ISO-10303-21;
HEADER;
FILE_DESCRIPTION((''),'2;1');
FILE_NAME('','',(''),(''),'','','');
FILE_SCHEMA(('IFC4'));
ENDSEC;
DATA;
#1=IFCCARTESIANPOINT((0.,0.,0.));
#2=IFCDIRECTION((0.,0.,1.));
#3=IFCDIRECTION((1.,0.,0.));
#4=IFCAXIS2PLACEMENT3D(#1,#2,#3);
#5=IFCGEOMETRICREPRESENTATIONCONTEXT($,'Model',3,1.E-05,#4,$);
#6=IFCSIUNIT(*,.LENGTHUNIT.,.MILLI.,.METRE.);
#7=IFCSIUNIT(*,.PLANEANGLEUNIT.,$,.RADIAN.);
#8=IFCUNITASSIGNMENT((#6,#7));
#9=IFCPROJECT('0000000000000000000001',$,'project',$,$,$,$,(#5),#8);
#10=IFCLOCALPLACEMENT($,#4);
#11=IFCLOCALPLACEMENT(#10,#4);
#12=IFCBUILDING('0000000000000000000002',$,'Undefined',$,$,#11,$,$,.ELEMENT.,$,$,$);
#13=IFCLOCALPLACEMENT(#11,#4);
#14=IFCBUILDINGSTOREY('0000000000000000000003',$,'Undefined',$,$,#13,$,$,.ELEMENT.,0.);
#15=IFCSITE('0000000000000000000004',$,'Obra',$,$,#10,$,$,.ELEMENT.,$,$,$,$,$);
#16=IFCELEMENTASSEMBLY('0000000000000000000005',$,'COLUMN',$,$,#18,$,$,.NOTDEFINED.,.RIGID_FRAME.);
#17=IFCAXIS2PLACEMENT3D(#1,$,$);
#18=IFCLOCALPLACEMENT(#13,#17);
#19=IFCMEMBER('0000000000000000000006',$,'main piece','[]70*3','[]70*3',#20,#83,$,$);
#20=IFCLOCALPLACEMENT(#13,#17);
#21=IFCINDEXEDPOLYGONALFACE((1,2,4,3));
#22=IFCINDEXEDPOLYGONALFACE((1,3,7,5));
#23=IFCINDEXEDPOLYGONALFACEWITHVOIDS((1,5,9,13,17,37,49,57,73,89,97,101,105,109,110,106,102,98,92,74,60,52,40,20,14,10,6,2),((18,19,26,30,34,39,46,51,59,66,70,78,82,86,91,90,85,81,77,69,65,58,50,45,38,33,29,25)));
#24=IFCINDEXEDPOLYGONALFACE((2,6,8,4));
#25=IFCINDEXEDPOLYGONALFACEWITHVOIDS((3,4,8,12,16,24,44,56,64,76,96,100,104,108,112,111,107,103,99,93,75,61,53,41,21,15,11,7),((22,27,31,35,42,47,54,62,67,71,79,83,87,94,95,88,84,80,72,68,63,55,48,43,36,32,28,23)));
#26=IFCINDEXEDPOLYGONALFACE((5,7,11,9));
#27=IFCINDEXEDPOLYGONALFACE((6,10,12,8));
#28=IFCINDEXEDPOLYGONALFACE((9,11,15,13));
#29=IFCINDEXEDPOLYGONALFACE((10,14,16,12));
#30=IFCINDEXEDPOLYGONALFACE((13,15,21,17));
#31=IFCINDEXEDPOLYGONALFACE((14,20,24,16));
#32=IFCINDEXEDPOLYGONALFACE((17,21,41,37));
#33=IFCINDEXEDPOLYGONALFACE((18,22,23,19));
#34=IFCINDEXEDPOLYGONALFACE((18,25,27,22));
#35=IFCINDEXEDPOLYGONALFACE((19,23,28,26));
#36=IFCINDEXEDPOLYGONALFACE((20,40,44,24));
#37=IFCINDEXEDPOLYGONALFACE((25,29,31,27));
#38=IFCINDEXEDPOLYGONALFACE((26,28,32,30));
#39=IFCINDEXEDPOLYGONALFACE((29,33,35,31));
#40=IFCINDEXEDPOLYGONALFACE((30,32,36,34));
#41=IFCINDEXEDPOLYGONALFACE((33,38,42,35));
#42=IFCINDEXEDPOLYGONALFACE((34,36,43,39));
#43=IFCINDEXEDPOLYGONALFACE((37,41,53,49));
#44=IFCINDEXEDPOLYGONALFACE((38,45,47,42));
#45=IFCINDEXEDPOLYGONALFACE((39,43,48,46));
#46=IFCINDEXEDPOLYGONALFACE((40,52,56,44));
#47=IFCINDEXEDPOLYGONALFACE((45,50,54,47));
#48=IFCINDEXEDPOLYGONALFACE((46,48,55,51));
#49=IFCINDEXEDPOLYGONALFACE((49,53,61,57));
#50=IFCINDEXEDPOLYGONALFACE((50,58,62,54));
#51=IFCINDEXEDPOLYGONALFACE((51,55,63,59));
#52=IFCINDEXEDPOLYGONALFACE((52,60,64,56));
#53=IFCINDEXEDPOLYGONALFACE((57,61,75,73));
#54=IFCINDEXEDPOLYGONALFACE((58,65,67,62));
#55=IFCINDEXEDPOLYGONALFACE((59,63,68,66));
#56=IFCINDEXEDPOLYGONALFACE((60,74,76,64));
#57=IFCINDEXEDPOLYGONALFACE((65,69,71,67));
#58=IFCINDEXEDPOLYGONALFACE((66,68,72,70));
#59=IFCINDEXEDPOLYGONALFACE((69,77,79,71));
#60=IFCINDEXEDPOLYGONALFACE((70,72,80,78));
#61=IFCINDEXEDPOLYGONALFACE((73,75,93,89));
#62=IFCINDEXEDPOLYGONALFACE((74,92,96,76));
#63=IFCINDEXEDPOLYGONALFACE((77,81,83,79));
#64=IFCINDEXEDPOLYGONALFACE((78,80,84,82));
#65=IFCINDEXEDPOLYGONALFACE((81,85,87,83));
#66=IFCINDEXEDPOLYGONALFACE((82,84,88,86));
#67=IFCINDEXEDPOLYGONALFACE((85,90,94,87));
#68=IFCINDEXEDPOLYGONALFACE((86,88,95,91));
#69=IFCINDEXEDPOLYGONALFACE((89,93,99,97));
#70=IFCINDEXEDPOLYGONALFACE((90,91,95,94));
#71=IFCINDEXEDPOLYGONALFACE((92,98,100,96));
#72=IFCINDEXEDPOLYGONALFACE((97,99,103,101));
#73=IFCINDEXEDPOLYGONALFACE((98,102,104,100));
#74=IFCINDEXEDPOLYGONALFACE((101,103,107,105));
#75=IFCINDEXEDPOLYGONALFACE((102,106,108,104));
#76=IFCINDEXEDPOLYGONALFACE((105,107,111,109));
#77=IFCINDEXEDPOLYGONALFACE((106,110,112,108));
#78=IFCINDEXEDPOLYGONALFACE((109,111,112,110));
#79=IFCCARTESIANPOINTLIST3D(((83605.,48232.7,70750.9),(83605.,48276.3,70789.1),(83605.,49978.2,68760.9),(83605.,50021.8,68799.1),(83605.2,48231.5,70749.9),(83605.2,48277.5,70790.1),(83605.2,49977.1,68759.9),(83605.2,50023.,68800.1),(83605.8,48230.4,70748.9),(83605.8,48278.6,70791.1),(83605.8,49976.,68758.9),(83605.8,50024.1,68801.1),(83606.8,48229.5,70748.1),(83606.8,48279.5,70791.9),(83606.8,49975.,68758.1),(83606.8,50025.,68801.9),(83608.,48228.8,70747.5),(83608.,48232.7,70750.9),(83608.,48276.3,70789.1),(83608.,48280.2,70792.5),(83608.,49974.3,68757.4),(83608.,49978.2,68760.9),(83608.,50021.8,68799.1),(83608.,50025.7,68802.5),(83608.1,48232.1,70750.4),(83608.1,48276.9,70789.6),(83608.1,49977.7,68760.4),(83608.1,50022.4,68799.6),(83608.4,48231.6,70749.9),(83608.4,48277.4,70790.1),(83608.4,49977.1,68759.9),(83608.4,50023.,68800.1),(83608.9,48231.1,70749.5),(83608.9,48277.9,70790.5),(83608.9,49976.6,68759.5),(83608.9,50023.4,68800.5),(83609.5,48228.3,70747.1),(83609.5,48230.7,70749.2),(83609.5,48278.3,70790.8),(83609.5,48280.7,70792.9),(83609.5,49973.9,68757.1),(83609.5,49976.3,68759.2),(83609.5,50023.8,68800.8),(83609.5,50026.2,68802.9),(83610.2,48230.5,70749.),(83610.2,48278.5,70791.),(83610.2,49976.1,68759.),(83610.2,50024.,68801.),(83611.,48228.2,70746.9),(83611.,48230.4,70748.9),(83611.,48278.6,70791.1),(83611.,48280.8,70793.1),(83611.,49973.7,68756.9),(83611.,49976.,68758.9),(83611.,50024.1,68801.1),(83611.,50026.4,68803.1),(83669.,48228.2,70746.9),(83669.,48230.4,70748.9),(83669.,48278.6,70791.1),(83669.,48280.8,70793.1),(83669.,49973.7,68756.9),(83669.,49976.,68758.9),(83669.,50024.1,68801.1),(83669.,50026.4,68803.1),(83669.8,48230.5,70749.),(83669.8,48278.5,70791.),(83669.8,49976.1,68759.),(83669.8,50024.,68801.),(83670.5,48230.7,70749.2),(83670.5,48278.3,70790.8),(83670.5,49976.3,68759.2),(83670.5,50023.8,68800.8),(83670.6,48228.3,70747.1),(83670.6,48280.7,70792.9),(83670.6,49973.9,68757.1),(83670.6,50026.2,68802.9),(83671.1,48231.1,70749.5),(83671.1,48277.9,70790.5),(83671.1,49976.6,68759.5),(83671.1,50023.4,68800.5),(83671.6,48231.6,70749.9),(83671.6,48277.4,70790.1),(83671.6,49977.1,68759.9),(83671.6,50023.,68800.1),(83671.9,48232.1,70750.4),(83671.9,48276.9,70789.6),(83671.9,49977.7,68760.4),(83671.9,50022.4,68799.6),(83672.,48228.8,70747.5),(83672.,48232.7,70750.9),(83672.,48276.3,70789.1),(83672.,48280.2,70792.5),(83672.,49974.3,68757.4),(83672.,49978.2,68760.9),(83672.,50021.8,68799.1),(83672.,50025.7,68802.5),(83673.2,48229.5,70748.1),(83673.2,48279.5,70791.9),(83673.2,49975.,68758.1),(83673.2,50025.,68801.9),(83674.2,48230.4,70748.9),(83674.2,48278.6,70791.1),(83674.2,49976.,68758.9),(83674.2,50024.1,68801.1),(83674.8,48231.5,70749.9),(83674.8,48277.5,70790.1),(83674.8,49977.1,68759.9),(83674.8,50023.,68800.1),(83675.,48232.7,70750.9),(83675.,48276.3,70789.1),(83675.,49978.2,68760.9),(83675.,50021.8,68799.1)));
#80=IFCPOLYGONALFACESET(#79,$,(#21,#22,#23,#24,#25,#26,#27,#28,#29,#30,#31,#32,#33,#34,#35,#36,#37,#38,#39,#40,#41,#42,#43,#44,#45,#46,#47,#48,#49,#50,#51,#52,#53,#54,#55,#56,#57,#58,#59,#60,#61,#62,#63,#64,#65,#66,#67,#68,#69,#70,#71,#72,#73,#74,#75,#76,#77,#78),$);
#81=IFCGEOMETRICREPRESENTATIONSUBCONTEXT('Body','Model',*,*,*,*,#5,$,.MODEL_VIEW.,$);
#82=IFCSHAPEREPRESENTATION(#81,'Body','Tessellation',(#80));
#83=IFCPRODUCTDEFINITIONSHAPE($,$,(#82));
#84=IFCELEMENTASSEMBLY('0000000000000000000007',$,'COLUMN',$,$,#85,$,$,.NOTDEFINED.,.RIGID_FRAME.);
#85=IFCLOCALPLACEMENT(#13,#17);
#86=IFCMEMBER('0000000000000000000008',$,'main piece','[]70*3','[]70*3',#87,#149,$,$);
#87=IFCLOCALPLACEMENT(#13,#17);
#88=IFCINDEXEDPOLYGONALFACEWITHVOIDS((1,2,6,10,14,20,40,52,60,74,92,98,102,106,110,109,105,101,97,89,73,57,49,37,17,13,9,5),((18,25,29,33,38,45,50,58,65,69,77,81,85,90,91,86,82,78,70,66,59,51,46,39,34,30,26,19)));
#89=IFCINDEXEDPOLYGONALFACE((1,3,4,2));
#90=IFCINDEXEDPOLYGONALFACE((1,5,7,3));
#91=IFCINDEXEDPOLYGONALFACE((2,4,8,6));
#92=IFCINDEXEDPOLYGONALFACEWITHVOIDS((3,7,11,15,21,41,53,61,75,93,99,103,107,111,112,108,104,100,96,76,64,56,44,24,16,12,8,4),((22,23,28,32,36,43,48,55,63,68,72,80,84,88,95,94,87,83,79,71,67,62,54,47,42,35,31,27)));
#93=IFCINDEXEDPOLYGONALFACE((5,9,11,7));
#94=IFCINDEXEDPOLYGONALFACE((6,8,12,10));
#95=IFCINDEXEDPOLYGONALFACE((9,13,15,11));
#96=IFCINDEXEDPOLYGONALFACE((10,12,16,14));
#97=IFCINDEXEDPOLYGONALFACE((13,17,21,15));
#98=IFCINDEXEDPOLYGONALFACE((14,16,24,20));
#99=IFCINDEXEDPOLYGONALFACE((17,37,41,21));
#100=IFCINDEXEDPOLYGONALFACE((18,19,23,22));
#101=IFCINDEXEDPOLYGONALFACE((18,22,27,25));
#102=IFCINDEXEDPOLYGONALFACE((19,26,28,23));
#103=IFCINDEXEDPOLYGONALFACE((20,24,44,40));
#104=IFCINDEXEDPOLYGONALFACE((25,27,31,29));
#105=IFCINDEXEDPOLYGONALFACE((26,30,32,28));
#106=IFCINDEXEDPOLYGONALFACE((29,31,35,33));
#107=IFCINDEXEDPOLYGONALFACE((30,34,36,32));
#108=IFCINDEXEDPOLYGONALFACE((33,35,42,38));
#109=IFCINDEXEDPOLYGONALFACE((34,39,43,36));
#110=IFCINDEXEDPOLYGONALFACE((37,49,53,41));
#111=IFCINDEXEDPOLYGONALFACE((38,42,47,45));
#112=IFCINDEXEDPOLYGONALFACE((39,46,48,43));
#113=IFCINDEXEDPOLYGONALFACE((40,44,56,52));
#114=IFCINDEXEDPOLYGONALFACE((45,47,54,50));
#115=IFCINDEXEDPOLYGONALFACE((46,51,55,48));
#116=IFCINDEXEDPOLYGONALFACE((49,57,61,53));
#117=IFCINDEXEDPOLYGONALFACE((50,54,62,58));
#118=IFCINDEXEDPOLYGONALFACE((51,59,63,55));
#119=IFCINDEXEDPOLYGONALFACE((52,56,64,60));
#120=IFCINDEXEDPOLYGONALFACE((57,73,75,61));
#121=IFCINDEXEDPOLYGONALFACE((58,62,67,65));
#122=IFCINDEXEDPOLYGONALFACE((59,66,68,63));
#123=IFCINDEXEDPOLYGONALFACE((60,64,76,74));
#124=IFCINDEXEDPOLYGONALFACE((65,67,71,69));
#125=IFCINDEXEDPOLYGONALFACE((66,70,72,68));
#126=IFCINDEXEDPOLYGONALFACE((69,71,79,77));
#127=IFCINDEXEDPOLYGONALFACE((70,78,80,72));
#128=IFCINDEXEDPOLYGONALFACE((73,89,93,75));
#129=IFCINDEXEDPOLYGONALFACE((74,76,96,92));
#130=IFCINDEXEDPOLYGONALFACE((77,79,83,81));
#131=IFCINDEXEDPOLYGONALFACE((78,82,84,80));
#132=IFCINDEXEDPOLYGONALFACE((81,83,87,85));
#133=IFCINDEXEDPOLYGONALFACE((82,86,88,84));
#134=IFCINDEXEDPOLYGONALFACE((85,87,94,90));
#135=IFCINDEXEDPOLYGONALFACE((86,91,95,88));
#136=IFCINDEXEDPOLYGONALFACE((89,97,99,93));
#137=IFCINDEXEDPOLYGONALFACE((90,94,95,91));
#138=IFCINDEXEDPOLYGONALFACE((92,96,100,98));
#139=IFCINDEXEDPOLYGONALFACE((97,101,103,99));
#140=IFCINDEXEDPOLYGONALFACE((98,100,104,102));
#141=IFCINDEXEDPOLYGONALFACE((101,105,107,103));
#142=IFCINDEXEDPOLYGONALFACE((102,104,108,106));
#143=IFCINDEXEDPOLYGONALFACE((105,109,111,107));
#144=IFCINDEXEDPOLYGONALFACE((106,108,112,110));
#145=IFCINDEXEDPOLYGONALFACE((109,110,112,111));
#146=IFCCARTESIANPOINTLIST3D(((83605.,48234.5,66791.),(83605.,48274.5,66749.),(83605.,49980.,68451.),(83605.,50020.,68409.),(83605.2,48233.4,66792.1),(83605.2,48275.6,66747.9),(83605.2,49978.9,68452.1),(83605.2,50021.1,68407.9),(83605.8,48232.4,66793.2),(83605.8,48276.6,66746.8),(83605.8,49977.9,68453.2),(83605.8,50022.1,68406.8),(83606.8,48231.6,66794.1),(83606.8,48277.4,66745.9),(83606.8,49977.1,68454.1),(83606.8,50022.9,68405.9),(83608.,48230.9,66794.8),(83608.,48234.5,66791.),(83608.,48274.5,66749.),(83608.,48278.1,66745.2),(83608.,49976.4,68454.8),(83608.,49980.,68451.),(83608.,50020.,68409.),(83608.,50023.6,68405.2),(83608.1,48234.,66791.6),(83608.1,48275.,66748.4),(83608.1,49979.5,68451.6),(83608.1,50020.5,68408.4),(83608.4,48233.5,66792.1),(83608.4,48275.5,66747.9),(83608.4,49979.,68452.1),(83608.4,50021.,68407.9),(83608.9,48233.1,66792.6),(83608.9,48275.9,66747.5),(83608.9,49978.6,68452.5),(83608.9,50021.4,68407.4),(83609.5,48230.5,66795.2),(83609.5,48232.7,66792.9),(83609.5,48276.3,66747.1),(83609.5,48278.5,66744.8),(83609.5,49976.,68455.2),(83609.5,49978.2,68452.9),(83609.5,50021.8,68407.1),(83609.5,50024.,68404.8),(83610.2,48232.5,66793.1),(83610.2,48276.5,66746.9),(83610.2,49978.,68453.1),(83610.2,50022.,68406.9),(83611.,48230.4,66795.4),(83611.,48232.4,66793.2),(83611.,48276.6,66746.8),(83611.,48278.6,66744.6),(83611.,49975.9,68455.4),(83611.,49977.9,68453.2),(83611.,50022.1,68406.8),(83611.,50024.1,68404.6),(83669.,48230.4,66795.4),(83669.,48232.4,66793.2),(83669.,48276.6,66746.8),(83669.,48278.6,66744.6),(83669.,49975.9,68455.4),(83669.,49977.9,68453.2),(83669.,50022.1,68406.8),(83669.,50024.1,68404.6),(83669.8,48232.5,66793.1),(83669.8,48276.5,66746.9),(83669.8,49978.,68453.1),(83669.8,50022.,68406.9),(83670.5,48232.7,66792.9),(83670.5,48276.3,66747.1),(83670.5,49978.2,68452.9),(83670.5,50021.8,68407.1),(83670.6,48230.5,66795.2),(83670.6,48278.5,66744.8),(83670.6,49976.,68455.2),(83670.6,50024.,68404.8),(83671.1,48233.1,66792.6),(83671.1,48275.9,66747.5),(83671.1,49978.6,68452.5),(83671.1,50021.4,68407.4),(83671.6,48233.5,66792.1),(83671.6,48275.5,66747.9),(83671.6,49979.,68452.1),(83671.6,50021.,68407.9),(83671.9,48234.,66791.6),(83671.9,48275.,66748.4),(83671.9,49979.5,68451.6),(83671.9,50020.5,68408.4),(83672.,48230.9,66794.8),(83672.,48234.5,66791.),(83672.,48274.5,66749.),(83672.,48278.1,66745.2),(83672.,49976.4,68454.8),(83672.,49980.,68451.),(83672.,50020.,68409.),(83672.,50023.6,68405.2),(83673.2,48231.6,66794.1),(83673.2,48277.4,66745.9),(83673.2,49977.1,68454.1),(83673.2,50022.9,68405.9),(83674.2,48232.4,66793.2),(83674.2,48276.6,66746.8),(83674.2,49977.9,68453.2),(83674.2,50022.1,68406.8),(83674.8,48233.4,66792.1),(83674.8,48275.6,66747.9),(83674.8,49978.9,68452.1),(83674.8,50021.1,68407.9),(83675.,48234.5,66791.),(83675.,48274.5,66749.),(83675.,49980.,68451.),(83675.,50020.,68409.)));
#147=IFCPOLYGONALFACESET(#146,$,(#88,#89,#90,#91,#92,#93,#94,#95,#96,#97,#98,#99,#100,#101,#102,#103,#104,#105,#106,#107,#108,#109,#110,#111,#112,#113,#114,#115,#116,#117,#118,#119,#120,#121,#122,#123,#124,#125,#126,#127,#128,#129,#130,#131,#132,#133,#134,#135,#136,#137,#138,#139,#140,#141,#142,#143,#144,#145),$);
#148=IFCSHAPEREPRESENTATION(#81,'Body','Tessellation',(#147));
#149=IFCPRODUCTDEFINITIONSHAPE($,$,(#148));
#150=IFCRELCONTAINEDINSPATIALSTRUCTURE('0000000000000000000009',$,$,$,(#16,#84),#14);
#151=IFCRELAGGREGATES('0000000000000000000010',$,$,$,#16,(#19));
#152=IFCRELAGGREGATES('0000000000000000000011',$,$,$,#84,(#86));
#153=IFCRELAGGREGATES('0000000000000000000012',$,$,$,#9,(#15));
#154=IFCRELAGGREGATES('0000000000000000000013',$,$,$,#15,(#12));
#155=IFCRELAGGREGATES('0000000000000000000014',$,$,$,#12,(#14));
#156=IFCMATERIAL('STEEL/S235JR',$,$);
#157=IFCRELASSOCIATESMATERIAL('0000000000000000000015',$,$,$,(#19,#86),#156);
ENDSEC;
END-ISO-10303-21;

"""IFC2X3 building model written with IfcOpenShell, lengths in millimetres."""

from ifc_helpers import new_model, si_unit, frame, origin_with_axes, origin_2d_with_axis, place, context, subcontext, project, spatial, hollow_rectangle, extrude, material, element, aggregate, save


model = new_model("IFC2X3")

# Units and contexts
model_context = context("Model", 3, precision=1e-05, world=origin_with_axes())
body_context = subcontext(model_context, "Body", "Model", "MODEL_VIEW")
ifc_project = project(units=[si_unit("LENGTHUNIT", "METRE", prefix="MILLI"), si_unit("PLANEANGLEUNIT", "RADIAN")], contexts=[model_context])

# Site, building, storey
site_placement = place(None, origin_with_axes())
site = spatial("IfcSite", under=ifc_project, at=site_placement, Name="Obra", CompositionType="ELEMENT")
building_placement = place(site_placement, origin_with_axes())
building = spatial("IfcBuilding", under=site, at=building_placement, Name="Undefined", CompositionType="ELEMENT")
storey_placement = place(building_placement, origin_with_axes())
storey = spatial("IfcBuildingStorey", under=building, at=storey_placement, Name="Undefined", CompositionType="ELEMENT", Elevation=0.0)

# Shared definitions
ifc_material = material(Name="STEEL/S235JR")

# Element assemblies, members
assembly_1_placement = place(storey_placement, origin_with_axes())
assembly_1 = element("IfcElementAssembly", 1, at=assembly_1_placement, inside=storey, Name="COLUMN", AssemblyPlace="NOTDEFINED", PredefinedType="RIGID_FRAME")
member_1_placement = place(assembly_1_placement, frame((83640.0, 50000.0, 68780.0), z_axis=(1.0, 0.0, 0.0), x_axis=(0.0, -0.659423, 0.751772)))
member_1 = element("IfcMember", 2, at=member_1_placement, material=ifc_material, Name="main piece", Description="[]70*3", ObjectType="[]70*3", context=body_context, shape_type="SweptSolid", body=[
    extrude(hollow_rectangle(XDim=70.0, YDim=70.0, WallThickness=3.0, InnerFilletRadius=3.0, OuterFilletRadius=6.0, at=origin_2d_with_axis()), frame((2647.1, 0.0, 0.0), z_axis=(-1.0, 0.0, 0.0), x_axis=(0.0, -1.0, 0.0)), (0.0, 0.0, 1.0), 2647.1),
])
aggregate(assembly_1, [member_1])
assembly_2_placement = place(storey_placement, origin_with_axes())
assembly_2 = element("IfcElementAssembly", 3, at=assembly_2_placement, inside=storey, Name="COLUMN", AssemblyPlace="NOTDEFINED", PredefinedType="RIGID_FRAME")
member_2_placement = place(assembly_2_placement, frame((83640.0, 48254.5, 66770.0), z_axis=(-1.0, 0.0, 0.0), x_axis=(0.0, 0.724633, 0.689135)))
member_2 = element("IfcMember", 4, at=member_2_placement, material=ifc_material, Name="main piece", Description="[]70*3", ObjectType="[]70*3", context=body_context, shape_type="SweptSolid", body=[
    extrude(hollow_rectangle(XDim=70.0, YDim=70.0, WallThickness=3.0, InnerFilletRadius=3.0, OuterFilletRadius=6.0, at=origin_2d_with_axis()), frame((2408.8, 0.0, 0.0), z_axis=(-1.0, 0.0, 0.0), x_axis=(0.0, -1.0, 0.0)), (0.0, 0.0, 1.0), 2408.8),
])
aggregate(assembly_2, [member_2])

save(model, "model.ifc")
